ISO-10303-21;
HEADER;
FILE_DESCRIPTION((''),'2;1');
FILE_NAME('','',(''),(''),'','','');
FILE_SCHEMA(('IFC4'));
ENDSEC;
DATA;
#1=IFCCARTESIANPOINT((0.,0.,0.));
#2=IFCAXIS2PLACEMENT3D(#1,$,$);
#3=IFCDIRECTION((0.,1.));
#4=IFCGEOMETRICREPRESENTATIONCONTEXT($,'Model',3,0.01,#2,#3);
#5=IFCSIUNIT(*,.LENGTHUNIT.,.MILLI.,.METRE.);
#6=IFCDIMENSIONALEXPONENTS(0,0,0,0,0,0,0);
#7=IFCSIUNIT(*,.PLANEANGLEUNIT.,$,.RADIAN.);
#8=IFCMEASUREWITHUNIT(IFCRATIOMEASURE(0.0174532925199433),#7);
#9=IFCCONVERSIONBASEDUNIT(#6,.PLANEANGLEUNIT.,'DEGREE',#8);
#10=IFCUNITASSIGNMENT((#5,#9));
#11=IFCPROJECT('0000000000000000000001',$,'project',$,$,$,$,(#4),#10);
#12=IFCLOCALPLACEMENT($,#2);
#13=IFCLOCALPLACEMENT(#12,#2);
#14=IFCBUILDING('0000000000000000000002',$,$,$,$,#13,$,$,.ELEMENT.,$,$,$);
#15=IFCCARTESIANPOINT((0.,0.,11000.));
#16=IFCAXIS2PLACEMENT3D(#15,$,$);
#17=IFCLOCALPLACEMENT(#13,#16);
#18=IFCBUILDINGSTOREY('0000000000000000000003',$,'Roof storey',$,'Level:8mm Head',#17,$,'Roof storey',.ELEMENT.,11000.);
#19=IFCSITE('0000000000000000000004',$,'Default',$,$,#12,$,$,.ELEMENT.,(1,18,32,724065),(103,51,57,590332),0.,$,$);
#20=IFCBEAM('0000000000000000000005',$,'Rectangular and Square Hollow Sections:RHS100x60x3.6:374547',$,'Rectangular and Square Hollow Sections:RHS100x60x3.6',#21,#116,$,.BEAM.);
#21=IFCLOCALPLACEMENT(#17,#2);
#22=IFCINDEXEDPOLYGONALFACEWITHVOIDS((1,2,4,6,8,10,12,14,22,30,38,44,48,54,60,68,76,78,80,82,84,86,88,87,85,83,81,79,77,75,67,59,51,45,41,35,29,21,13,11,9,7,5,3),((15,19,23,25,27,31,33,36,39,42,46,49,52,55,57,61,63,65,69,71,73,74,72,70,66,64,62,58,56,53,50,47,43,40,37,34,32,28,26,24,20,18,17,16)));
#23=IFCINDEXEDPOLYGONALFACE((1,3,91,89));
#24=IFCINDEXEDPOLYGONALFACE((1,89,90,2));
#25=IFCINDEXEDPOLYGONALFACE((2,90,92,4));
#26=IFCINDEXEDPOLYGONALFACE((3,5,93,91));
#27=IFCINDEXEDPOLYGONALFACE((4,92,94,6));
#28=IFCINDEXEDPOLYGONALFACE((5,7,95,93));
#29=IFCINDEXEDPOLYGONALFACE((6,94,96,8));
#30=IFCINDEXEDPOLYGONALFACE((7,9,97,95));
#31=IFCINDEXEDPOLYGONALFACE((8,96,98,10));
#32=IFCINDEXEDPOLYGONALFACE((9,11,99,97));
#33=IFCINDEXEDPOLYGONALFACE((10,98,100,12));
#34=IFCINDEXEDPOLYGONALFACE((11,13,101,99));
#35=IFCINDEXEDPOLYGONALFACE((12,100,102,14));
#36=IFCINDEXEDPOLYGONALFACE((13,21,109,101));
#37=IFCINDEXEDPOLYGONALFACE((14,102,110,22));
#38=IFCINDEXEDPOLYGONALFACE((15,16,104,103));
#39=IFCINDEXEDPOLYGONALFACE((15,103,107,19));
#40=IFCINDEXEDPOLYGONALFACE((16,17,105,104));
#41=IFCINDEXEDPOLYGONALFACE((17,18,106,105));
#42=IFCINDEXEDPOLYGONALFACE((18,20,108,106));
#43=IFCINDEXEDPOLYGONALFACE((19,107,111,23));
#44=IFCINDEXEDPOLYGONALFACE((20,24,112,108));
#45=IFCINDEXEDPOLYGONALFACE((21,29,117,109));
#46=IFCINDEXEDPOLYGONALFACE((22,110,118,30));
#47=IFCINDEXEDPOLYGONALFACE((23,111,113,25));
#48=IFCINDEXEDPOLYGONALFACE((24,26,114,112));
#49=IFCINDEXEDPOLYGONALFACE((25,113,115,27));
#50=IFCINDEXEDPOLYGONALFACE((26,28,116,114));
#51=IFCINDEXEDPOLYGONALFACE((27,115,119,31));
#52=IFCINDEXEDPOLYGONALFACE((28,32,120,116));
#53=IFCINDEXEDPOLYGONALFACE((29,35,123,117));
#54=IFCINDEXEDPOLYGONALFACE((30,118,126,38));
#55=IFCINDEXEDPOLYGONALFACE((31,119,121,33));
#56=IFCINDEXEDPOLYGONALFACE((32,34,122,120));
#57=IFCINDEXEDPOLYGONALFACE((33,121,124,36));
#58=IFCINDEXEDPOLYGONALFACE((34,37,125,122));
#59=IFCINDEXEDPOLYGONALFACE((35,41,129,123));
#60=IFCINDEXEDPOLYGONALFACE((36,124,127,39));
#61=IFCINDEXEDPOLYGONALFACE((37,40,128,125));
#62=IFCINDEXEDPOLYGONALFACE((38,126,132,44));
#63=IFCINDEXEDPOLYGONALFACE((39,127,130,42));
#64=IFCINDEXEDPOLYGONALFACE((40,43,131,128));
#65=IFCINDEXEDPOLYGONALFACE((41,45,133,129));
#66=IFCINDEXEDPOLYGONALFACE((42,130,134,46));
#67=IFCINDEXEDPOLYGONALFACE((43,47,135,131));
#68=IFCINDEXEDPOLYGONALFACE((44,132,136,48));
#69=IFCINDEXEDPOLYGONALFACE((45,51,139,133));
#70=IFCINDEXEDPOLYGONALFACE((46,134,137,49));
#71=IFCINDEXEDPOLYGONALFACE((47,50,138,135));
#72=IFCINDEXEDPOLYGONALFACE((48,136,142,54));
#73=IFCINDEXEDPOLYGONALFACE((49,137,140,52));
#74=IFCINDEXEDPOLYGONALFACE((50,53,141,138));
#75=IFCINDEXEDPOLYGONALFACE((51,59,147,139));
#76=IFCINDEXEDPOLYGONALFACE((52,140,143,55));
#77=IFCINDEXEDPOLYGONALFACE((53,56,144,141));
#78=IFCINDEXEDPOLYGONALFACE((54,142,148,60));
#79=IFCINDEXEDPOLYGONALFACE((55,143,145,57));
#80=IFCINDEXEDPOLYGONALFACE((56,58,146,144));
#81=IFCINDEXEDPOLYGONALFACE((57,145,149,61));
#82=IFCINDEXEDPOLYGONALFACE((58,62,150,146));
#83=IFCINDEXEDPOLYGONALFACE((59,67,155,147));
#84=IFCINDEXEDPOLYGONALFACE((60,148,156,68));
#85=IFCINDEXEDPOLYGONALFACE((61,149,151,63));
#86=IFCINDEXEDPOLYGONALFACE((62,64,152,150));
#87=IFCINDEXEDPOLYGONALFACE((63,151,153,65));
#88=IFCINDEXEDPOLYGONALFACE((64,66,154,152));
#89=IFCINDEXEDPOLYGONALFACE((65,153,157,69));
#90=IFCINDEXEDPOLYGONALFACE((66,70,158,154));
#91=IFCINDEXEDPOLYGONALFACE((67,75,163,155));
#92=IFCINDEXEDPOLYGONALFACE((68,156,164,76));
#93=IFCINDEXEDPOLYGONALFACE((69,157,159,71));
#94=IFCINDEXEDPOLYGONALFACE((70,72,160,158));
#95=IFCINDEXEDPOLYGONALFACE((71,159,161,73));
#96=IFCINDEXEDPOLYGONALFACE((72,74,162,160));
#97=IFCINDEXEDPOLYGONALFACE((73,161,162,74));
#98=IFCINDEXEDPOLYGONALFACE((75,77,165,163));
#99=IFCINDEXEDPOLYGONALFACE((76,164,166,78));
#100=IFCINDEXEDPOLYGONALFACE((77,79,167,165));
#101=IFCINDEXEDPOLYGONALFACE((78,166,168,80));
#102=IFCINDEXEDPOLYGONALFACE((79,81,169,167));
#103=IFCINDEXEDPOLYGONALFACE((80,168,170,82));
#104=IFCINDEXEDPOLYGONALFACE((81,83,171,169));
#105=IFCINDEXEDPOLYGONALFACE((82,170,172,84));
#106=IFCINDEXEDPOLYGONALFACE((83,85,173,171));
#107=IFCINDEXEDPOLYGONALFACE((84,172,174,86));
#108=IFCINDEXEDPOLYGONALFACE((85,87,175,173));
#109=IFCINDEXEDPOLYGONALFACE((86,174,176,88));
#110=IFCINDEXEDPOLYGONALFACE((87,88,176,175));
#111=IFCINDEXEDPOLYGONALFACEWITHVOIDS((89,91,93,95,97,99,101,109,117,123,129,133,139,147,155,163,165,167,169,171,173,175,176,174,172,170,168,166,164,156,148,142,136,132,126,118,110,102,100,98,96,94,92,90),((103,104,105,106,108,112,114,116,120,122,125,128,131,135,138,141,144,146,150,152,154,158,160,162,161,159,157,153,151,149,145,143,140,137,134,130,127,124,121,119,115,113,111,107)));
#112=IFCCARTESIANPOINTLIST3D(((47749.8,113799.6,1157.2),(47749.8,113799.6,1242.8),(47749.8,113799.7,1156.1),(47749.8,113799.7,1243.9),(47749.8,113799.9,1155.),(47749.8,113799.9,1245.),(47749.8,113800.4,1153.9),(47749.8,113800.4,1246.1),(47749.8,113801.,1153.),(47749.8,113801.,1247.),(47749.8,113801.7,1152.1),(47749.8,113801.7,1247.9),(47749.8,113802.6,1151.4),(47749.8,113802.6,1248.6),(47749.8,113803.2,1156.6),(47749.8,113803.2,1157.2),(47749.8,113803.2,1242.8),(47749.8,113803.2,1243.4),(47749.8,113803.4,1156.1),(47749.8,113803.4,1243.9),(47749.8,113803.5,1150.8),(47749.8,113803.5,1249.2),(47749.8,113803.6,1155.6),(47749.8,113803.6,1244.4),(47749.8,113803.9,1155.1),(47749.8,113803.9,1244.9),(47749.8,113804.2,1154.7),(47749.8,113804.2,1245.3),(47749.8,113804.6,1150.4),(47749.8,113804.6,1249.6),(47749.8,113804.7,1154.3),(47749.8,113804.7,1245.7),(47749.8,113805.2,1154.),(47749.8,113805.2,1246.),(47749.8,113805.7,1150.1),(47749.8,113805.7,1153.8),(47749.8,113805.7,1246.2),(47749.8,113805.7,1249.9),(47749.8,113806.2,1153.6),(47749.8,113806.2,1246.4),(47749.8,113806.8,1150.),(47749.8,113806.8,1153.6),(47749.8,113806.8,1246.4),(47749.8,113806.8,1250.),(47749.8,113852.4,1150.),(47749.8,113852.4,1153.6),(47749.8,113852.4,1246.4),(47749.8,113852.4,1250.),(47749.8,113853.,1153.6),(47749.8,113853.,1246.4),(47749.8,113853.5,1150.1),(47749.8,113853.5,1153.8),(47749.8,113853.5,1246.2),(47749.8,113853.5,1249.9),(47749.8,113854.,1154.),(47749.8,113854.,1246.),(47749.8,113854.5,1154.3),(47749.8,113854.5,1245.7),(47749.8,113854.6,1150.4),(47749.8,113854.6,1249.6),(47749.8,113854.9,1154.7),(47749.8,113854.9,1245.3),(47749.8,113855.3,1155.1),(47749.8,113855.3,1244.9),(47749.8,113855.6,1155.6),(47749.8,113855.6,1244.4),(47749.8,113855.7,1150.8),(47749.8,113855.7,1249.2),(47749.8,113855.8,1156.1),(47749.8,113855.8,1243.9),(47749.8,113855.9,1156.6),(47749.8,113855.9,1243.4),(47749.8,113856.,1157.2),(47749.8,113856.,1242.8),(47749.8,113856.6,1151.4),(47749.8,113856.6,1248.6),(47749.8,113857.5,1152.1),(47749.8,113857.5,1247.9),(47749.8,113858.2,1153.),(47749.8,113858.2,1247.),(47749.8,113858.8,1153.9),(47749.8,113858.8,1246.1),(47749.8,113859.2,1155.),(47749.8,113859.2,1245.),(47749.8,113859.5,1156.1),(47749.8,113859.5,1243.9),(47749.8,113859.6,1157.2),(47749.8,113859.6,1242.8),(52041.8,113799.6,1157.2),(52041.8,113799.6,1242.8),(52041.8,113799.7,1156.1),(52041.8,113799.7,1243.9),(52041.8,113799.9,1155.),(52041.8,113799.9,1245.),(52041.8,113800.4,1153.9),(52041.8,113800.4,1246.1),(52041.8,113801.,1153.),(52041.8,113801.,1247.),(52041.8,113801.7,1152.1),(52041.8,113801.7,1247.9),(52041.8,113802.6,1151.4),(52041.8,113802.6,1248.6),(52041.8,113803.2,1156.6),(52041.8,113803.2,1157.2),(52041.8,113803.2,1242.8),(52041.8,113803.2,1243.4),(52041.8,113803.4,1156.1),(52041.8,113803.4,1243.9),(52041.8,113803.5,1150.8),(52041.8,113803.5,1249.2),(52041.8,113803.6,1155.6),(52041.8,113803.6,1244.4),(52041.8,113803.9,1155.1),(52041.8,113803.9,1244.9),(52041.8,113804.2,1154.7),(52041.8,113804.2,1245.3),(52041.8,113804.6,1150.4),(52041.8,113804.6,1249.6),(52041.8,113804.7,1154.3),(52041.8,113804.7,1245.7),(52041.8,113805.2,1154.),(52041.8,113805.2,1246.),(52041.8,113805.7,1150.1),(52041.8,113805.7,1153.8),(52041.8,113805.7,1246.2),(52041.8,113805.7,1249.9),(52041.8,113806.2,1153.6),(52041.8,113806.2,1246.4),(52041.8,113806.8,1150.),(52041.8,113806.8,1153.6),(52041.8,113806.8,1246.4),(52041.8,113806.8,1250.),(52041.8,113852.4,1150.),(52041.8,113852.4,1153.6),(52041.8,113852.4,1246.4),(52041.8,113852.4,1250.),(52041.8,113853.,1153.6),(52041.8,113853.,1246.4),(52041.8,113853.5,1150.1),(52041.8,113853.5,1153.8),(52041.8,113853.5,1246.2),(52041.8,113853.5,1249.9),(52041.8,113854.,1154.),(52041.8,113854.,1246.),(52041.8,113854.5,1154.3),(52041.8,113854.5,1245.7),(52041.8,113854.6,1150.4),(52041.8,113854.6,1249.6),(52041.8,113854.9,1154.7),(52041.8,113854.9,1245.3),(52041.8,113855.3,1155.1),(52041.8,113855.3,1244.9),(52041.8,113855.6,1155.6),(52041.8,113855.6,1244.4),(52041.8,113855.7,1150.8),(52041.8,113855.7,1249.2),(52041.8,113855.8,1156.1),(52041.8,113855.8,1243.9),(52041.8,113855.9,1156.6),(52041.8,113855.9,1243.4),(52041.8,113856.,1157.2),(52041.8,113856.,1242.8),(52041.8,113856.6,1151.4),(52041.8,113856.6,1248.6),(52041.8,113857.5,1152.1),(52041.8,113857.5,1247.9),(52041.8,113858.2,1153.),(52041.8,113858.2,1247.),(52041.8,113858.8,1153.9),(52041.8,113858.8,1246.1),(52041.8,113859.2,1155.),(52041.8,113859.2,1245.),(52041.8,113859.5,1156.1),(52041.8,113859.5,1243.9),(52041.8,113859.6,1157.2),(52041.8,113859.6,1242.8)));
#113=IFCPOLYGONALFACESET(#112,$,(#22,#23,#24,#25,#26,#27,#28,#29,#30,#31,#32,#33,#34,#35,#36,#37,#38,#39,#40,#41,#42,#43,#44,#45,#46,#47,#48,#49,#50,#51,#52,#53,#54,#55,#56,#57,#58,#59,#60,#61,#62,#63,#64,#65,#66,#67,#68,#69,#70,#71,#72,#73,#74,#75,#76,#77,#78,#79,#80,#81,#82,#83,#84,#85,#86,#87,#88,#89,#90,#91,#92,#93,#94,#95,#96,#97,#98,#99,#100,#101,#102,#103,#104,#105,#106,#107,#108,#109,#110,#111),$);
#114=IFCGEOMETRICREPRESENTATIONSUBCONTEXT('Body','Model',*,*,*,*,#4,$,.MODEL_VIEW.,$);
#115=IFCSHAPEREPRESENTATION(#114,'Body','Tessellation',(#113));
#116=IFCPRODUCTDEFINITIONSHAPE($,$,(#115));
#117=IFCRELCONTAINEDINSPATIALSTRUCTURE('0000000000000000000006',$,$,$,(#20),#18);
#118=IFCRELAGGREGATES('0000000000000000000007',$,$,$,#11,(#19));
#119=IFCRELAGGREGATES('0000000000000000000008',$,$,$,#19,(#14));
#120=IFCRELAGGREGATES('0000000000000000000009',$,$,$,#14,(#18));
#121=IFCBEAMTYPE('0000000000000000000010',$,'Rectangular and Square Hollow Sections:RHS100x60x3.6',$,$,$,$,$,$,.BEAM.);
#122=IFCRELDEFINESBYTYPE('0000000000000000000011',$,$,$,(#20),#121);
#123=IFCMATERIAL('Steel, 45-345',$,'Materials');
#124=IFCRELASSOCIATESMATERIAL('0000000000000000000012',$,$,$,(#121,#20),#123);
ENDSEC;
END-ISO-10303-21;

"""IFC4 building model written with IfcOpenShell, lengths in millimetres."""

from ifc_helpers import new_model, entity, si_unit, converted_unit, direction, frame, origin, place, context, subcontext, project, spatial, indexed_curve, outline, extrude, source, transform, mapped, material, type_object, type_shapes, element, save


model = new_model("IFC4")

# Units and contexts
model_context = context("Model", 3, precision=0.01, world=origin(), true_north=direction((0.0, 1.0)))
body_context = subcontext(model_context, "Body", "Model", "MODEL_VIEW")
ifc_project = project(units=[si_unit("LENGTHUNIT", "METRE", prefix="MILLI"), converted_unit("PLANEANGLEUNIT", "DEGREE", entity("IfcRatioMeasure", 0.0174532925199433), si_unit("PLANEANGLEUNIT", "RADIAN"), dimensions=[0, 0, 0, 0, 0, 0, 0])], contexts=[model_context])

# Site, building, storey
site_placement = place(None, origin())
site = spatial("IfcSite", under=ifc_project, at=site_placement, Name="Default", CompositionType="ELEMENT", RefLatitude=(1, 18, 32, 724065), RefLongitude=(103, 51, 57, 590332), RefElevation=0.0)
building_placement = place(site_placement, origin())
building = spatial("IfcBuilding", under=site, at=building_placement, CompositionType="ELEMENT")
storey_placement = place(building_placement, frame((0.0, 0.0, 11000.0)))
storey = spatial("IfcBuildingStorey", under=building, at=storey_placement, Name="Roof storey", ObjectType="Level:8mm Head", LongName="Roof storey", CompositionType="ELEMENT", Elevation=11000.0)

# Shared definitions
ifc_material = material(Name="Steel, 45-345", Category="Materials")

# Beam
beam_type_1 = type_object("IfcBeamType", Name="Rectangular and Square Hollow Sections:RHS100x60x3.6", PredefinedType="BEAM", material=ifc_material)
shared_shape_1 = source(origin(), body_context, "Body", "SweptSolid", [
    extrude(outline(indexed_curve([(-30.0, -42.8), (-29.9, -43.9), (-29.6, -45.0), (-29.2, -46.1), (-28.6, -47.0), (-27.9, -47.9), (-27.0, -48.6), (-26.1, -49.2), (-25.0, -49.6), (-23.9, -49.9), (-22.8, -50.0), (22.8, -50.0), (23.9, -49.9), (25.0, -49.6), (26.1, -49.2), (27.0, -48.6), (27.9, -47.9), (28.6, -47.0), (29.2, -46.1), (29.6, -45.0), (29.9, -43.9), (30.0, -42.8), (30.0, 42.8), (29.9, 43.9), (29.6, 45.0), (29.2, 46.1), (28.6, 47.0), (27.9, 47.9), (27.0, 48.6), (26.1, 49.2), (25.0, 49.6), (23.9, 49.9), (22.8, 50.0), (-22.8, 50.0), (-23.9, 49.9), (-25.0, 49.6), (-26.1, 49.2), (-27.0, 48.6), (-27.9, 47.9), (-28.6, 47.0), (-29.2, 46.1), (-29.6, 45.0), (-29.9, 43.9), (-30.0, 42.8), (-30.0, -42.8)], self_intersect=False), holes=[indexed_curve([(22.8, -46.4), (-22.8, -46.4), (-23.4, -46.4), (-23.9, -46.2), (-24.4, -46.0), (-24.9, -45.7), (-25.3, -45.3), (-25.7, -44.9), (-26.0, -44.4), (-26.2, -43.9), (-26.4, -43.4), (-26.4, -42.8), (-26.4, 42.8), (-26.4, 43.4), (-26.2, 43.9), (-26.0, 44.4), (-25.7, 44.9), (-25.3, 45.3), (-24.9, 45.7), (-24.4, 46.0), (-23.9, 46.2), (-23.4, 46.4), (-22.8, 46.4), (22.8, 46.4), (23.4, 46.4), (23.9, 46.2), (24.4, 46.0), (24.9, 45.7), (25.3, 45.3), (25.7, 44.9), (26.0, 44.4), (26.2, 43.9), (26.4, 43.4), (26.4, 42.8), (26.4, -42.8), (26.4, -43.4), (26.2, -43.9), (26.0, -44.4), (25.7, -44.9), (25.3, -45.3), (24.9, -45.7), (24.4, -46.0), (23.9, -46.2), (23.4, -46.4), (22.8, -46.4)], self_intersect=False)]), frame((-2139.5, 0.0, 0.0), z_axis=(1.0, 0.0, 0.0), x_axis=(0.0, -1.0, 0.0)), (0.0, 0.0, 1.0), 4292.0),
])
type_shapes(beam_type_1, [shared_shape_1])
for number, where, name in (
    (1, (49889.3, 113829.6, 1200.0), "Rectangular and Square Hollow Sections:RHS100x60x3.6:374547"),
):
    element("IfcBeam", number, at=place(storey_placement, frame(where)), inside=storey, type_object=beam_type_1, material=ifc_material, Name=name, ObjectType="Rectangular and Square Hollow Sections:RHS100x60x3.6", PredefinedType="BEAM", context=body_context, shape_type="MappedRepresentation", body=[
        mapped(shared_shape_1, transform((0.0, 0.0, 0.0), scale=1.0)),
    ])

save(model, "model.ifc")
